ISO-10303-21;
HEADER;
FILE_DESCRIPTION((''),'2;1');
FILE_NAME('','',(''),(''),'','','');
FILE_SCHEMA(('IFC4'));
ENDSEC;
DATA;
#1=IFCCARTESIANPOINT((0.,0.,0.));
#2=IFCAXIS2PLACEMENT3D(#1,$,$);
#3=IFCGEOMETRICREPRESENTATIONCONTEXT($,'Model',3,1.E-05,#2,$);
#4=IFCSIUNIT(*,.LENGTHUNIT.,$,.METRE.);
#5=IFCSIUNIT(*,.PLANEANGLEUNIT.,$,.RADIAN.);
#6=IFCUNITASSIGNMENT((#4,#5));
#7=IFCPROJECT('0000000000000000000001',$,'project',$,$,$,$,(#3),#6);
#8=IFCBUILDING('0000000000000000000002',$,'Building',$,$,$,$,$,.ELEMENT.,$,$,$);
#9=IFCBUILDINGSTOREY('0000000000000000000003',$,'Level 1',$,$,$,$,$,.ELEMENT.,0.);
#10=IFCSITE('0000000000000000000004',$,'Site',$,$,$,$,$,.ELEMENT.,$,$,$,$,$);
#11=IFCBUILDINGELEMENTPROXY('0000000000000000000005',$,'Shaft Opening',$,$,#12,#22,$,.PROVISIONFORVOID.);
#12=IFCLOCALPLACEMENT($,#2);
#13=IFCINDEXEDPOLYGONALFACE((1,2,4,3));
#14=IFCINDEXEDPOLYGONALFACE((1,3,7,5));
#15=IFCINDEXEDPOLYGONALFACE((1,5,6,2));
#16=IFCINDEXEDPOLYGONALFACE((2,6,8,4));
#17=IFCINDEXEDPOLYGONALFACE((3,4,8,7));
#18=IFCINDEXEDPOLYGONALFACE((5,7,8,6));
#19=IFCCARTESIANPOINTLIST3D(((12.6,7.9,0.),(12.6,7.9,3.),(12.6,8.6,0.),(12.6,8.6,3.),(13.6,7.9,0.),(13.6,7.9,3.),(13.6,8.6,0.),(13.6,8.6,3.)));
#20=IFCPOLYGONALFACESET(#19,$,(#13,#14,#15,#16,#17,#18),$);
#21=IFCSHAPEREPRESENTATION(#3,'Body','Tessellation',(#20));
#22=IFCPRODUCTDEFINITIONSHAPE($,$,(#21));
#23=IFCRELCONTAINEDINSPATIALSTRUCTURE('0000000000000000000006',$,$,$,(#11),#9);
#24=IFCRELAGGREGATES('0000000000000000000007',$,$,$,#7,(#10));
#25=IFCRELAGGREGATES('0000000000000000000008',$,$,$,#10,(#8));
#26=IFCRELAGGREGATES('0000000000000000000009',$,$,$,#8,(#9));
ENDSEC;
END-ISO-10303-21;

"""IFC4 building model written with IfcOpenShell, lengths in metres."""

from ifc_helpers import new_model, si_unit, frame, origin, place, context, project, spatial, polyline, outline, extrude, element, save


model = new_model("IFC4")

# Units and contexts
model_context = context("Model", 3, precision=1e-05, world=origin())
ifc_project = project(units=[si_unit("LENGTHUNIT", "METRE"), si_unit("PLANEANGLEUNIT", "RADIAN")], contexts=[model_context])

# Site, building, storey
site = spatial("IfcSite", under=ifc_project, Name="Site", CompositionType="ELEMENT")
building = spatial("IfcBuilding", under=site, Name="Building", CompositionType="ELEMENT")
storey = spatial("IfcBuildingStorey", under=building, Name="Level 1", CompositionType="ELEMENT", Elevation=0.0)

# Building element proxy
proxy_placement = place(None, frame((0.0, 0.0, 3.0)))
element("IfcBuildingElementProxy", 1, at=proxy_placement, inside=storey, Name="Shaft Opening", PredefinedType="PROVISIONFORVOID", context=model_context, shape_type="SweptSolid", body=[
    extrude(outline(polyline([(12.6, 7.9), (13.6, 7.9), (13.6, 8.6), (12.6, 8.6), (12.6, 7.9)])), origin(), (0.0, 0.0, -1.0), 3.0),
])

save(model, "model.ifc")
